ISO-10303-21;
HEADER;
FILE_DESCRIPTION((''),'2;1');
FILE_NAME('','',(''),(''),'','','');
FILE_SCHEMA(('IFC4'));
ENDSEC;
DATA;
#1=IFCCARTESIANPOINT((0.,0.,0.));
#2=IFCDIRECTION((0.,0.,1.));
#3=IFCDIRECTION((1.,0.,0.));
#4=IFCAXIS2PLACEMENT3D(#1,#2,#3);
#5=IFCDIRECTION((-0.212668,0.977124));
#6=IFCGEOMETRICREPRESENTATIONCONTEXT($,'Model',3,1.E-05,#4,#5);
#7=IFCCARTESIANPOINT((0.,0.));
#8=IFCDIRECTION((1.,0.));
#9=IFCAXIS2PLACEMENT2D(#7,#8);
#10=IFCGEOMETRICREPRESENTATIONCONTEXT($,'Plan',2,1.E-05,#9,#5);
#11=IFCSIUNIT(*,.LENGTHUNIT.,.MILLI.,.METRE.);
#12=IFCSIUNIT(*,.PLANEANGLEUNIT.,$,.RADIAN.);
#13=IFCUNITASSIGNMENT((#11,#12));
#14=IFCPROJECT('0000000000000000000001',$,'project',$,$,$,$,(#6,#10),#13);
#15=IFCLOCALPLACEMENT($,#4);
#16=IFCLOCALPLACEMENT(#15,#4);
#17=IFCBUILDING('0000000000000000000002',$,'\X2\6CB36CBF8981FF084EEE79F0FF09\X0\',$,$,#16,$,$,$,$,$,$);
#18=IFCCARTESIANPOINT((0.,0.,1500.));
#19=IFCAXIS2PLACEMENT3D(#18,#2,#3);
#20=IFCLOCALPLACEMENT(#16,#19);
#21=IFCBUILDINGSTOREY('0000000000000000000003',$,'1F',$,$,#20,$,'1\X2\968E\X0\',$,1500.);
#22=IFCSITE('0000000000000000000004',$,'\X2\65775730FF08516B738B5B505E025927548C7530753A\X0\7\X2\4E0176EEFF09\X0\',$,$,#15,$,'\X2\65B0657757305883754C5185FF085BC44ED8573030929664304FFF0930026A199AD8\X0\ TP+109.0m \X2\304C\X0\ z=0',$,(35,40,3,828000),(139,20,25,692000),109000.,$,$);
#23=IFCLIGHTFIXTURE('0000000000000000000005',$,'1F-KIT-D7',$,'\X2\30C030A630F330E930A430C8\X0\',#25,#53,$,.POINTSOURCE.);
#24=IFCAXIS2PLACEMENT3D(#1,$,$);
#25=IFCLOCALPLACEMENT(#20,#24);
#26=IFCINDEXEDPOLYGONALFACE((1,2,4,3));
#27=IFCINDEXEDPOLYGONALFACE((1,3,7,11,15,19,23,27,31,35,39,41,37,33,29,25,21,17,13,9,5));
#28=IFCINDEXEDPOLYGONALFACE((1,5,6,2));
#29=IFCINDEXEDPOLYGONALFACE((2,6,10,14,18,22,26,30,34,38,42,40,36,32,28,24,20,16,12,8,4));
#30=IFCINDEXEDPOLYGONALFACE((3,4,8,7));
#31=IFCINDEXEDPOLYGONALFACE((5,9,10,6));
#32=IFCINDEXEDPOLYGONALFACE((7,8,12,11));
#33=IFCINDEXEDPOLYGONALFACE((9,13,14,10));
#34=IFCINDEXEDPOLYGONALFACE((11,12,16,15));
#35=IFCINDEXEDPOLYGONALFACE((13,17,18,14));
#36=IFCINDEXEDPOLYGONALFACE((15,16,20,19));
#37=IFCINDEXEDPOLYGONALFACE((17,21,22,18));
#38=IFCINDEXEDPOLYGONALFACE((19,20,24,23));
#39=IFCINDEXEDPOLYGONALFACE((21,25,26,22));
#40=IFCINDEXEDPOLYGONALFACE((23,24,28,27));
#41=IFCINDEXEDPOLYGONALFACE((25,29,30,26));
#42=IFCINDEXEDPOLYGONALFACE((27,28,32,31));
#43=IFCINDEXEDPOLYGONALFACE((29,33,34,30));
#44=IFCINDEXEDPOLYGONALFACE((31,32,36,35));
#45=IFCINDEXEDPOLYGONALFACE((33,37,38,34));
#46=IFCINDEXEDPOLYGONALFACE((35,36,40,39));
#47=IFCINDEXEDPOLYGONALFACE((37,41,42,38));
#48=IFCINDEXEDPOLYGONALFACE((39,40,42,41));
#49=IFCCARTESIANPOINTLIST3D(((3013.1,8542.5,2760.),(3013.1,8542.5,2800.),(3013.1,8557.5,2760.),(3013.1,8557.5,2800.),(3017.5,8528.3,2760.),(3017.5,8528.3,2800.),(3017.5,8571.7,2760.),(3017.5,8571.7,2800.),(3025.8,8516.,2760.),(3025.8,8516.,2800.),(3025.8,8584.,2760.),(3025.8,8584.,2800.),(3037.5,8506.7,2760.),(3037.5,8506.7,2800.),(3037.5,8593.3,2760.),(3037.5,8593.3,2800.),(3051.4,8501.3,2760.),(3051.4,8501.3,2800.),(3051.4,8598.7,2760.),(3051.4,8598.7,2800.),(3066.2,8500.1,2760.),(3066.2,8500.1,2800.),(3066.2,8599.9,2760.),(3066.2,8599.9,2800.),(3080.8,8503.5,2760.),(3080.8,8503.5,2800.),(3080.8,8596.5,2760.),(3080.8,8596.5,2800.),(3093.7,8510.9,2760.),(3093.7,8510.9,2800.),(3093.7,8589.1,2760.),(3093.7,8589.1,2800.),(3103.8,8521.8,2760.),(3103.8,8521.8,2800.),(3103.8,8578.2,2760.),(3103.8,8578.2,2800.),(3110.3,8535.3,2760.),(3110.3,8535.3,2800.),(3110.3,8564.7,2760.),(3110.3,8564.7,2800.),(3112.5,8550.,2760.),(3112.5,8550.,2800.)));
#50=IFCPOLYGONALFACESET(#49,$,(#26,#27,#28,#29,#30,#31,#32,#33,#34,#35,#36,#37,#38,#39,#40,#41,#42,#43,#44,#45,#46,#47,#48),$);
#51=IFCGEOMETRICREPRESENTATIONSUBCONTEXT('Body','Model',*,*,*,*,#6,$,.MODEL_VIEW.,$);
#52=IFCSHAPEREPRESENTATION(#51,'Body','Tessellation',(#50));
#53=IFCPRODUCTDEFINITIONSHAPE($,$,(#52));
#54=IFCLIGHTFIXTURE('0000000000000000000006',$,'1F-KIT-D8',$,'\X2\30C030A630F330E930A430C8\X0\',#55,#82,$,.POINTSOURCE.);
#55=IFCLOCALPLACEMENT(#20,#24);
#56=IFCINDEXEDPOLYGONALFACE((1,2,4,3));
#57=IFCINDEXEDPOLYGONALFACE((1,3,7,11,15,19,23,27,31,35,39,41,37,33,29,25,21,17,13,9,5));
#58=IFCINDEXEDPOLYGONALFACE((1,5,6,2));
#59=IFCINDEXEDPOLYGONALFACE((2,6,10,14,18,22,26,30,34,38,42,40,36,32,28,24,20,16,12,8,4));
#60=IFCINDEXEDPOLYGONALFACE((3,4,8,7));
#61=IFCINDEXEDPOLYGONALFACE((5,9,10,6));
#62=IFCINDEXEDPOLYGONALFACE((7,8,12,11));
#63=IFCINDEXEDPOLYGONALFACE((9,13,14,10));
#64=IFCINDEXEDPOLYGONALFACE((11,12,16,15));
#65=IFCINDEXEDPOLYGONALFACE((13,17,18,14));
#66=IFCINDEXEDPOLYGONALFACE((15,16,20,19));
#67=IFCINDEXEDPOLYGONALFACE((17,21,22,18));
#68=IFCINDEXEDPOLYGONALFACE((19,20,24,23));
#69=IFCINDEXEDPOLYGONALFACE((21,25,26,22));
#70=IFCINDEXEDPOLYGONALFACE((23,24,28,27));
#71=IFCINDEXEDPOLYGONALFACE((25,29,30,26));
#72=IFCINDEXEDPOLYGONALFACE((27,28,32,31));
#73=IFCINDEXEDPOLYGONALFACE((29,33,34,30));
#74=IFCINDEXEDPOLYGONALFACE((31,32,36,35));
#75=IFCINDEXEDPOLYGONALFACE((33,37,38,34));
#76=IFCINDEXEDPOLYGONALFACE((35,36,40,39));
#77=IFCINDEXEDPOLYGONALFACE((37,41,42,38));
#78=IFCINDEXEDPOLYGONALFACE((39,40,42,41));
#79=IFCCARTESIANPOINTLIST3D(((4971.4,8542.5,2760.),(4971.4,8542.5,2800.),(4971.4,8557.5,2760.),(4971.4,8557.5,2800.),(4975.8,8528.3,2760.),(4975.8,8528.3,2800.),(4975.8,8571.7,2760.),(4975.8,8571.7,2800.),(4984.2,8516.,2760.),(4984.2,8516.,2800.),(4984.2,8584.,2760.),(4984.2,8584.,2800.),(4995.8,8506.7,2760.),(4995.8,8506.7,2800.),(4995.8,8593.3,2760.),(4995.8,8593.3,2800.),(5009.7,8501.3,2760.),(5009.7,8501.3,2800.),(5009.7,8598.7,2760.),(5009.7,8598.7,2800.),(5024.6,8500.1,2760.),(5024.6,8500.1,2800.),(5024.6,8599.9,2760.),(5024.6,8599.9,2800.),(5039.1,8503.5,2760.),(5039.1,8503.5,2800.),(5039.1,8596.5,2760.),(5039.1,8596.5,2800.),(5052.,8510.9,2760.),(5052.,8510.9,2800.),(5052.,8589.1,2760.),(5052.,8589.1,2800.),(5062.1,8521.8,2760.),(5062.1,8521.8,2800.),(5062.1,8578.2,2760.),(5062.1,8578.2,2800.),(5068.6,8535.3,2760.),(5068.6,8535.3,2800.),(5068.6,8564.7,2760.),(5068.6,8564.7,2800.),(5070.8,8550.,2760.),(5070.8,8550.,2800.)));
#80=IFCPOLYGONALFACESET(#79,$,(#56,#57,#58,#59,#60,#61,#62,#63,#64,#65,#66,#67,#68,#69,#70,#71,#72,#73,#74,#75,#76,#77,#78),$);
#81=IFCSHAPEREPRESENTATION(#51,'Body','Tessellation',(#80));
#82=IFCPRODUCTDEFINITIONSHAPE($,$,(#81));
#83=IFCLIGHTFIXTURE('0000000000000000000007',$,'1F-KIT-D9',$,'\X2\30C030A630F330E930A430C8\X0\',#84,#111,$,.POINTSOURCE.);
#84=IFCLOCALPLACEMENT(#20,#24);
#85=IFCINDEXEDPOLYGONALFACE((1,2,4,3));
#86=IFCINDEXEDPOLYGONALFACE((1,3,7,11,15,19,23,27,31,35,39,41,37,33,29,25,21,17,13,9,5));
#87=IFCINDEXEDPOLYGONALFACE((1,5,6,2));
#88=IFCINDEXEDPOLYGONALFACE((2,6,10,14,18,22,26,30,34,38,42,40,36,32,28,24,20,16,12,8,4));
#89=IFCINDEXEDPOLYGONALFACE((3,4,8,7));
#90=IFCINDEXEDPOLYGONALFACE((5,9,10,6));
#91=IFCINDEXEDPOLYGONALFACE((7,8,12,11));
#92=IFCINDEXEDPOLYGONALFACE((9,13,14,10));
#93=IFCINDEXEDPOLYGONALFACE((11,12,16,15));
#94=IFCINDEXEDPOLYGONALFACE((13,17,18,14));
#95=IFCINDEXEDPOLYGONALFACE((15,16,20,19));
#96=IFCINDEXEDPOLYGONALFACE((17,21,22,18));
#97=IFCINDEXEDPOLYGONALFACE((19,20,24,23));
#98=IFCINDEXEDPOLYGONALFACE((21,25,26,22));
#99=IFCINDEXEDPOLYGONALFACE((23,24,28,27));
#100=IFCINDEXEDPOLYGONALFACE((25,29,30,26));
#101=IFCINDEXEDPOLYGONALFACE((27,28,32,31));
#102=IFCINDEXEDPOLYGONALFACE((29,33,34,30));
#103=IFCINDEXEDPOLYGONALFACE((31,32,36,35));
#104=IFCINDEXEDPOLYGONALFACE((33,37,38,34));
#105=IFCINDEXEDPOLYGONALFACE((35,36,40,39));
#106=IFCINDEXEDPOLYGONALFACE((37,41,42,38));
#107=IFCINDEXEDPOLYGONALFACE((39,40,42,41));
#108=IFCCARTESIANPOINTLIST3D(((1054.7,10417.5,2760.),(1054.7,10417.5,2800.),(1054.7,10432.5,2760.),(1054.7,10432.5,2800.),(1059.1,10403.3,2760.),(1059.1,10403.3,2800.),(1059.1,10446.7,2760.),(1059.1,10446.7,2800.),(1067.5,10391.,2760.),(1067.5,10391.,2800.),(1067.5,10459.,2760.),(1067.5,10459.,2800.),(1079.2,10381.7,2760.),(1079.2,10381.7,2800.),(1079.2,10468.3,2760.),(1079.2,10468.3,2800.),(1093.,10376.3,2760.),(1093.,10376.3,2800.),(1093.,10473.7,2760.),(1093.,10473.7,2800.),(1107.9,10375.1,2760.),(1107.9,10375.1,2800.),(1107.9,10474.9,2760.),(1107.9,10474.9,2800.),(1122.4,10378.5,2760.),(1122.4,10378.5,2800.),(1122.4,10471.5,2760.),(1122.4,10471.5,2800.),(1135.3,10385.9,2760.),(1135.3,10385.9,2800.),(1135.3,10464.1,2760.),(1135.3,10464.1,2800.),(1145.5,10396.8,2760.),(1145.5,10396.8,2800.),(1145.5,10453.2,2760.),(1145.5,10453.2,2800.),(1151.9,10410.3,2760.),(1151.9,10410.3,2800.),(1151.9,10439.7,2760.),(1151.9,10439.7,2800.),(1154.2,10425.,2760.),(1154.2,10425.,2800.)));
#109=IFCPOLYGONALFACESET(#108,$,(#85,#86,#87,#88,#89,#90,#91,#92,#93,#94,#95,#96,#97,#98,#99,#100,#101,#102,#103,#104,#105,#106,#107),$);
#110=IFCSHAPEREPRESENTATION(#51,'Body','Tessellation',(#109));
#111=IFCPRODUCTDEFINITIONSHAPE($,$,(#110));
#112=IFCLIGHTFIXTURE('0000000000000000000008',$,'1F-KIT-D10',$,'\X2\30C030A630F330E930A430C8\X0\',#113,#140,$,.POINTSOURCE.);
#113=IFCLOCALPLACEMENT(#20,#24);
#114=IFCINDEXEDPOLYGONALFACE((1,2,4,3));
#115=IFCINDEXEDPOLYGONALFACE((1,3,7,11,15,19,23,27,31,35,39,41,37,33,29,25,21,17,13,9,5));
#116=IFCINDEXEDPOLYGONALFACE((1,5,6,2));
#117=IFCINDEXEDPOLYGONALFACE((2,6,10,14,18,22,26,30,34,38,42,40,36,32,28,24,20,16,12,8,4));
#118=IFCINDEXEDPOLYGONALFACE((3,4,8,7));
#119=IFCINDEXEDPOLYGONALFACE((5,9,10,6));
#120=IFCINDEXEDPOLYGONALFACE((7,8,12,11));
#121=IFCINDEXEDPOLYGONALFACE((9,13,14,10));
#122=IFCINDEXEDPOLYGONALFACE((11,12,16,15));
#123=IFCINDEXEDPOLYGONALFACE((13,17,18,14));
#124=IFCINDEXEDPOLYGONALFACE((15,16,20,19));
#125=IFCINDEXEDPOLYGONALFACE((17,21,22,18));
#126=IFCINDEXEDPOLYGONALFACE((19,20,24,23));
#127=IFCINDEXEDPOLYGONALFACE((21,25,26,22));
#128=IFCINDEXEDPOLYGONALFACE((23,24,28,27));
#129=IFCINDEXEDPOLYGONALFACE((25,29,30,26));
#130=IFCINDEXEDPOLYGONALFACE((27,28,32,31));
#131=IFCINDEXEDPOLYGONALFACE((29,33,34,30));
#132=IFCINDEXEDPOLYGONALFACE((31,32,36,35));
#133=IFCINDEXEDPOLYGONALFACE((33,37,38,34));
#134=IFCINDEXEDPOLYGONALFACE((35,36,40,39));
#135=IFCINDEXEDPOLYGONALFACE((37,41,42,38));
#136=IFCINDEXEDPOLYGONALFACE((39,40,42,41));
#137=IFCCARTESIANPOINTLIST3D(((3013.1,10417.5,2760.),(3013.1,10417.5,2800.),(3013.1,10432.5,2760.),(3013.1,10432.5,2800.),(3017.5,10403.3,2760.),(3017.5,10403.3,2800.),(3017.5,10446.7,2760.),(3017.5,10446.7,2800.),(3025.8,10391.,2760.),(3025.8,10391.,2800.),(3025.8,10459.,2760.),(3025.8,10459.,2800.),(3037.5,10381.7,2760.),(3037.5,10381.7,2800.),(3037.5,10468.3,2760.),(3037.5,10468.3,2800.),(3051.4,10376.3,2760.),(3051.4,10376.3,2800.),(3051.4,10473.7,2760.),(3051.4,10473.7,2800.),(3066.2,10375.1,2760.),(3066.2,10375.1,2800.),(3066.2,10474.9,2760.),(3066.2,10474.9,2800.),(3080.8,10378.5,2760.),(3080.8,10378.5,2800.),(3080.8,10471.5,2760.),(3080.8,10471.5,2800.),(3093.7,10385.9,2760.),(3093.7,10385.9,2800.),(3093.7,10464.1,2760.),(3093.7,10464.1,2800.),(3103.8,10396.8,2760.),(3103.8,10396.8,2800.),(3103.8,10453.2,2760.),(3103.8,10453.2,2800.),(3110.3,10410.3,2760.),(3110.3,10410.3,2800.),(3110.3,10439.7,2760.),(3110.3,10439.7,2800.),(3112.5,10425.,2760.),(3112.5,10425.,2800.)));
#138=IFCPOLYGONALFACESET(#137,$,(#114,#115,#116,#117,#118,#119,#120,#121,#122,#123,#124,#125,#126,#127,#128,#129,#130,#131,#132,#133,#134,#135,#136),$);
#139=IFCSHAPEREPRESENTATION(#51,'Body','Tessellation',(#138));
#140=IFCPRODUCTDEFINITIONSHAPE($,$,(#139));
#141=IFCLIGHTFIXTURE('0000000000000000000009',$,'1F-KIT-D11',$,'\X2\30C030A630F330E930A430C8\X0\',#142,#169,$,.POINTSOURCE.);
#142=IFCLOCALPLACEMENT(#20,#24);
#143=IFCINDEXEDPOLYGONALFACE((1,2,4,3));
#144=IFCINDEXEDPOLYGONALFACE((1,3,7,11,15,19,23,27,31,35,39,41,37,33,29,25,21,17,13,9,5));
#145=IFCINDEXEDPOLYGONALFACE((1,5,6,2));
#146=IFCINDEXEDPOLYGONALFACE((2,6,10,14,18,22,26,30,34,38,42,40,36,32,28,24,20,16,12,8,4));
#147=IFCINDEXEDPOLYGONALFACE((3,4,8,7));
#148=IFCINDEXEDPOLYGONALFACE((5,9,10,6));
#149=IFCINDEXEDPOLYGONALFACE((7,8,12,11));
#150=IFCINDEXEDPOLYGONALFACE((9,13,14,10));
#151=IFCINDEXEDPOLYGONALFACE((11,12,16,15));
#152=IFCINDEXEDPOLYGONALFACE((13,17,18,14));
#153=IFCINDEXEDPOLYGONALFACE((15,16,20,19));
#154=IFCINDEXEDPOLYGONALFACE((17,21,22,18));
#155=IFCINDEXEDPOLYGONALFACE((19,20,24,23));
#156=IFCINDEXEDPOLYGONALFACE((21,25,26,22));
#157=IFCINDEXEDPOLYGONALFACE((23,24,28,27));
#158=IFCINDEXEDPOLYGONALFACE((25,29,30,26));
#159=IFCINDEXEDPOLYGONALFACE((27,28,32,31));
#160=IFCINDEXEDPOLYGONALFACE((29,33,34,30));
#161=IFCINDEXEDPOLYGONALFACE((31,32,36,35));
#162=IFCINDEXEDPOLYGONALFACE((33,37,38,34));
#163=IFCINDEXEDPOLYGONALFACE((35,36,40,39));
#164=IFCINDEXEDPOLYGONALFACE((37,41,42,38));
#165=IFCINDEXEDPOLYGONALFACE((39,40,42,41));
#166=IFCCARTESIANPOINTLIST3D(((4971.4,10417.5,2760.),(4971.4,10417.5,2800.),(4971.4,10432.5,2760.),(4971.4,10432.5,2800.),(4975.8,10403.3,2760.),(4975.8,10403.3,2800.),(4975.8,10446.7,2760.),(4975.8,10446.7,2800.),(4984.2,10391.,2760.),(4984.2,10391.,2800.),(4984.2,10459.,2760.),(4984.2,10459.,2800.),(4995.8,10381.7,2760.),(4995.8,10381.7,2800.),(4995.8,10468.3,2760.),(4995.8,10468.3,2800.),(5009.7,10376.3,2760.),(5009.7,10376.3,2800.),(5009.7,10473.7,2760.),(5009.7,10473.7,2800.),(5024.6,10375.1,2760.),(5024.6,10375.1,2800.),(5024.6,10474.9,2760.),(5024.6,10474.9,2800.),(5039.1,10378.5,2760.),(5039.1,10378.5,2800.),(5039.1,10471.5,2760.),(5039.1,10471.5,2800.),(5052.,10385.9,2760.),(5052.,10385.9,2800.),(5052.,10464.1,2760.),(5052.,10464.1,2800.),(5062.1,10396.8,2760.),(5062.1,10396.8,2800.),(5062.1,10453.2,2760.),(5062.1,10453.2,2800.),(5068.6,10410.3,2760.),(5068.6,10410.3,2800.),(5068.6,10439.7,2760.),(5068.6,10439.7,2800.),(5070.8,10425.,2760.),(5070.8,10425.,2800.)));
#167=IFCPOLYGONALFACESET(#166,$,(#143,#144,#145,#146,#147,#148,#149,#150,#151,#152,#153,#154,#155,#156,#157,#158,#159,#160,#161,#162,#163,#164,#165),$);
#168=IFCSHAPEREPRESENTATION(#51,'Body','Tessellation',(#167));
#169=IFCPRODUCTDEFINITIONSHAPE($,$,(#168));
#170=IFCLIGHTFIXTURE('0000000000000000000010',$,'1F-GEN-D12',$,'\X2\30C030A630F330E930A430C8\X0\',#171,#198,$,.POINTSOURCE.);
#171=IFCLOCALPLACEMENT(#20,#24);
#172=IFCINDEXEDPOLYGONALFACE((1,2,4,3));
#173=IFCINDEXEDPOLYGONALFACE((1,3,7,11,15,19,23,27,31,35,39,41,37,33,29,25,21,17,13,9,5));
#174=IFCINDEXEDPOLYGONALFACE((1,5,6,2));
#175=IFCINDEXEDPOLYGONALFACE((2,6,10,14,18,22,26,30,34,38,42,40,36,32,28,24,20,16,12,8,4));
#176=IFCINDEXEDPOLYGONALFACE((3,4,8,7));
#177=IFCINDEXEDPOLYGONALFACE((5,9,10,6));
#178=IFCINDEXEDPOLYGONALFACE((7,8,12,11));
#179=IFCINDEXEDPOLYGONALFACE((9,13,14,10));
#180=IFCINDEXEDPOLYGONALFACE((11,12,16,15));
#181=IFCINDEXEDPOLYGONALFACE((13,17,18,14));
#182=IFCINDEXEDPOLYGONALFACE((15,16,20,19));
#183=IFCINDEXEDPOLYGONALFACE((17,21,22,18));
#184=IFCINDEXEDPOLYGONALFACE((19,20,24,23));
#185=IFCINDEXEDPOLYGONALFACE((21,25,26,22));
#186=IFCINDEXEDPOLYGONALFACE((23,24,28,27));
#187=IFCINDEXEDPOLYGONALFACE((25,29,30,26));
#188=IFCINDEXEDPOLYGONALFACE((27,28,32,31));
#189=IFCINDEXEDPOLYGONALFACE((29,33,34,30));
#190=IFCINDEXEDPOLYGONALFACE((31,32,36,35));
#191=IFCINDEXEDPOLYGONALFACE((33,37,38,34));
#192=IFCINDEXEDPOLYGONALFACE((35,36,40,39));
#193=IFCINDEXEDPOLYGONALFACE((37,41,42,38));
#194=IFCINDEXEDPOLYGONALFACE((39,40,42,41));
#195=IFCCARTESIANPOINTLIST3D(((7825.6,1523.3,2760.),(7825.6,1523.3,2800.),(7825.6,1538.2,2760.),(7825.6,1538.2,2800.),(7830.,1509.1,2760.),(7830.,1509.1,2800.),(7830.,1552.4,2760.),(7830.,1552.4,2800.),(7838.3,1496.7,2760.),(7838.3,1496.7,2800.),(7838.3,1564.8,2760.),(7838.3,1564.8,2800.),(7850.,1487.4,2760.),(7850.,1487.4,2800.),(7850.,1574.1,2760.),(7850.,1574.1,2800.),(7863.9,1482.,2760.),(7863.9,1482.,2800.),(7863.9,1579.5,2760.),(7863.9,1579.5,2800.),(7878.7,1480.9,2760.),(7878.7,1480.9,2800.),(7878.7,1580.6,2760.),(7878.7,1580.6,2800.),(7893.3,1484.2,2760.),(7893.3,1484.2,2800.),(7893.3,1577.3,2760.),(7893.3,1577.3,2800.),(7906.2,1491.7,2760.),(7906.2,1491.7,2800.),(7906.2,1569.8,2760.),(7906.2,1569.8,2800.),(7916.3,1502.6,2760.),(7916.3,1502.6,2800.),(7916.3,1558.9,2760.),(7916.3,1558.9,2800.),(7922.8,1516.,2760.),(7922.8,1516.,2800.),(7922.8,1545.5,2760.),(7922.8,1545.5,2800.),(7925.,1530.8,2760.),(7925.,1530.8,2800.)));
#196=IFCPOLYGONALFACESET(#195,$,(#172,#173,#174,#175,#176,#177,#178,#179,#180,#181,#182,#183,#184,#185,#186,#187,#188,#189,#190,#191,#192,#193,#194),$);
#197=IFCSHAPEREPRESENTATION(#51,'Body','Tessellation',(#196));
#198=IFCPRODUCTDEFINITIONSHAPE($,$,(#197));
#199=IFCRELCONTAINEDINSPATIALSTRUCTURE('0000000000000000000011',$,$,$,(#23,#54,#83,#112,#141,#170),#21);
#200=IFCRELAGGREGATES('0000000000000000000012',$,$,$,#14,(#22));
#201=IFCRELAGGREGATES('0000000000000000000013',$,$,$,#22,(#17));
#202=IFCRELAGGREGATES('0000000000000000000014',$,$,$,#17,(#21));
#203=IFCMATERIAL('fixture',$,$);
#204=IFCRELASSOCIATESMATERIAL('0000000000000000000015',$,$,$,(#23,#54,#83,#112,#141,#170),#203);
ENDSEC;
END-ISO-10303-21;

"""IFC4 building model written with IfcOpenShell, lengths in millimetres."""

from ifc_helpers import new_model, si_unit, direction, frame, frame_2d, origin_with_axes, origin_2d_with_axis, place, context, subcontext, project, spatial, circle, extrude, material, element, save


model = new_model("IFC4")

# Units and contexts
model_context = context("Model", 3, precision=1e-05, world=origin_with_axes(), true_north=direction((-0.212668, 0.977124)))
plan_context = context("Plan", 2, precision=1e-05, world=origin_2d_with_axis(), true_north=direction((-0.212668, 0.977124)))
body_context = subcontext(model_context, "Body", "Model", "MODEL_VIEW")
ifc_project = project(units=[si_unit("LENGTHUNIT", "METRE", prefix="MILLI"), si_unit("PLANEANGLEUNIT", "RADIAN")], contexts=[model_context, plan_context])

# Site, building, storey
site_placement = place(None, origin_with_axes())
site = spatial("IfcSite", under=ifc_project, at=site_placement, Name="敷地（八王子市大和田町7丁目）", LongName="新敷地境界内（寄付地を除く）。標高 TP+109.0m が z=0", RefLatitude=(35, 40, 3, 828000), RefLongitude=(139, 20, 25, 692000), RefElevation=109000.0)
building_placement = place(site_placement, origin_with_axes())
building = spatial("IfcBuilding", under=site, at=building_placement, Name="河沿要（仮称）")
storey_placement = place(building_placement, frame((0.0, 0.0, 1500.0), z_axis=(0.0, 0.0, 1.0), x_axis=(1.0, 0.0, 0.0)))
storey = spatial("IfcBuildingStorey", under=building, at=storey_placement, Name="1F", LongName="1階", Elevation=1500.0)

# Light fixtures
ifc_material = material(Name="fixture")
light_fixture_1_placement = place(storey_placement, origin_with_axes())
element("IfcLightFixture", 1, at=light_fixture_1_placement, inside=storey, material=ifc_material, Name="1F-KIT-D7", ObjectType="ダウンライト", PredefinedType="POINTSOURCE", context=body_context, shape_type="SweptSolid", body=[
    extrude(circle(Radius=50.0, at=frame_2d((3062.5, 8550.0))), frame((0.0, 0.0, 2760.0)), (0.0, 0.0, 1.0), 40.0),
])
light_fixture_2_placement = place(storey_placement, origin_with_axes())
element("IfcLightFixture", 2, at=light_fixture_2_placement, inside=storey, material=ifc_material, Name="1F-KIT-D8", ObjectType="ダウンライト", PredefinedType="POINTSOURCE", context=body_context, shape_type="SweptSolid", body=[
    extrude(circle(Radius=50.0, at=frame_2d((5020.8, 8550.0))), frame((0.0, 0.0, 2760.0)), (0.0, 0.0, 1.0), 40.0),
])
light_fixture_3_placement = place(storey_placement, origin_with_axes())
element("IfcLightFixture", 3, at=light_fixture_3_placement, inside=storey, material=ifc_material, Name="1F-KIT-D9", ObjectType="ダウンライト", PredefinedType="POINTSOURCE", context=body_context, shape_type="SweptSolid", body=[
    extrude(circle(Radius=50.0, at=frame_2d((1104.2, 10425.0))), frame((0.0, 0.0, 2760.0)), (0.0, 0.0, 1.0), 40.0),
])
light_fixture_4_placement = place(storey_placement, origin_with_axes())
element("IfcLightFixture", 4, at=light_fixture_4_placement, inside=storey, material=ifc_material, Name="1F-KIT-D10", ObjectType="ダウンライト", PredefinedType="POINTSOURCE", context=body_context, shape_type="SweptSolid", body=[
    extrude(circle(Radius=50.0, at=frame_2d((3062.5, 10425.0))), frame((0.0, 0.0, 2760.0)), (0.0, 0.0, 1.0), 40.0),
])
light_fixture_5_placement = place(storey_placement, origin_with_axes())
element("IfcLightFixture", 5, at=light_fixture_5_placement, inside=storey, material=ifc_material, Name="1F-KIT-D11", ObjectType="ダウンライト", PredefinedType="POINTSOURCE", context=body_context, shape_type="SweptSolid", body=[
    extrude(circle(Radius=50.0, at=frame_2d((5020.8, 10425.0))), frame((0.0, 0.0, 2760.0)), (0.0, 0.0, 1.0), 40.0),
])
light_fixture_6_placement = place(storey_placement, origin_with_axes())
element("IfcLightFixture", 6, at=light_fixture_6_placement, inside=storey, material=ifc_material, Name="1F-GEN-D12", ObjectType="ダウンライト", PredefinedType="POINTSOURCE", context=body_context, shape_type="SweptSolid", body=[
    extrude(circle(Radius=50.0, at=frame_2d((7875.0, 1530.8))), frame((0.0, 0.0, 2760.0)), (0.0, 0.0, 1.0), 40.0),
])

save(model, "model.ifc")
